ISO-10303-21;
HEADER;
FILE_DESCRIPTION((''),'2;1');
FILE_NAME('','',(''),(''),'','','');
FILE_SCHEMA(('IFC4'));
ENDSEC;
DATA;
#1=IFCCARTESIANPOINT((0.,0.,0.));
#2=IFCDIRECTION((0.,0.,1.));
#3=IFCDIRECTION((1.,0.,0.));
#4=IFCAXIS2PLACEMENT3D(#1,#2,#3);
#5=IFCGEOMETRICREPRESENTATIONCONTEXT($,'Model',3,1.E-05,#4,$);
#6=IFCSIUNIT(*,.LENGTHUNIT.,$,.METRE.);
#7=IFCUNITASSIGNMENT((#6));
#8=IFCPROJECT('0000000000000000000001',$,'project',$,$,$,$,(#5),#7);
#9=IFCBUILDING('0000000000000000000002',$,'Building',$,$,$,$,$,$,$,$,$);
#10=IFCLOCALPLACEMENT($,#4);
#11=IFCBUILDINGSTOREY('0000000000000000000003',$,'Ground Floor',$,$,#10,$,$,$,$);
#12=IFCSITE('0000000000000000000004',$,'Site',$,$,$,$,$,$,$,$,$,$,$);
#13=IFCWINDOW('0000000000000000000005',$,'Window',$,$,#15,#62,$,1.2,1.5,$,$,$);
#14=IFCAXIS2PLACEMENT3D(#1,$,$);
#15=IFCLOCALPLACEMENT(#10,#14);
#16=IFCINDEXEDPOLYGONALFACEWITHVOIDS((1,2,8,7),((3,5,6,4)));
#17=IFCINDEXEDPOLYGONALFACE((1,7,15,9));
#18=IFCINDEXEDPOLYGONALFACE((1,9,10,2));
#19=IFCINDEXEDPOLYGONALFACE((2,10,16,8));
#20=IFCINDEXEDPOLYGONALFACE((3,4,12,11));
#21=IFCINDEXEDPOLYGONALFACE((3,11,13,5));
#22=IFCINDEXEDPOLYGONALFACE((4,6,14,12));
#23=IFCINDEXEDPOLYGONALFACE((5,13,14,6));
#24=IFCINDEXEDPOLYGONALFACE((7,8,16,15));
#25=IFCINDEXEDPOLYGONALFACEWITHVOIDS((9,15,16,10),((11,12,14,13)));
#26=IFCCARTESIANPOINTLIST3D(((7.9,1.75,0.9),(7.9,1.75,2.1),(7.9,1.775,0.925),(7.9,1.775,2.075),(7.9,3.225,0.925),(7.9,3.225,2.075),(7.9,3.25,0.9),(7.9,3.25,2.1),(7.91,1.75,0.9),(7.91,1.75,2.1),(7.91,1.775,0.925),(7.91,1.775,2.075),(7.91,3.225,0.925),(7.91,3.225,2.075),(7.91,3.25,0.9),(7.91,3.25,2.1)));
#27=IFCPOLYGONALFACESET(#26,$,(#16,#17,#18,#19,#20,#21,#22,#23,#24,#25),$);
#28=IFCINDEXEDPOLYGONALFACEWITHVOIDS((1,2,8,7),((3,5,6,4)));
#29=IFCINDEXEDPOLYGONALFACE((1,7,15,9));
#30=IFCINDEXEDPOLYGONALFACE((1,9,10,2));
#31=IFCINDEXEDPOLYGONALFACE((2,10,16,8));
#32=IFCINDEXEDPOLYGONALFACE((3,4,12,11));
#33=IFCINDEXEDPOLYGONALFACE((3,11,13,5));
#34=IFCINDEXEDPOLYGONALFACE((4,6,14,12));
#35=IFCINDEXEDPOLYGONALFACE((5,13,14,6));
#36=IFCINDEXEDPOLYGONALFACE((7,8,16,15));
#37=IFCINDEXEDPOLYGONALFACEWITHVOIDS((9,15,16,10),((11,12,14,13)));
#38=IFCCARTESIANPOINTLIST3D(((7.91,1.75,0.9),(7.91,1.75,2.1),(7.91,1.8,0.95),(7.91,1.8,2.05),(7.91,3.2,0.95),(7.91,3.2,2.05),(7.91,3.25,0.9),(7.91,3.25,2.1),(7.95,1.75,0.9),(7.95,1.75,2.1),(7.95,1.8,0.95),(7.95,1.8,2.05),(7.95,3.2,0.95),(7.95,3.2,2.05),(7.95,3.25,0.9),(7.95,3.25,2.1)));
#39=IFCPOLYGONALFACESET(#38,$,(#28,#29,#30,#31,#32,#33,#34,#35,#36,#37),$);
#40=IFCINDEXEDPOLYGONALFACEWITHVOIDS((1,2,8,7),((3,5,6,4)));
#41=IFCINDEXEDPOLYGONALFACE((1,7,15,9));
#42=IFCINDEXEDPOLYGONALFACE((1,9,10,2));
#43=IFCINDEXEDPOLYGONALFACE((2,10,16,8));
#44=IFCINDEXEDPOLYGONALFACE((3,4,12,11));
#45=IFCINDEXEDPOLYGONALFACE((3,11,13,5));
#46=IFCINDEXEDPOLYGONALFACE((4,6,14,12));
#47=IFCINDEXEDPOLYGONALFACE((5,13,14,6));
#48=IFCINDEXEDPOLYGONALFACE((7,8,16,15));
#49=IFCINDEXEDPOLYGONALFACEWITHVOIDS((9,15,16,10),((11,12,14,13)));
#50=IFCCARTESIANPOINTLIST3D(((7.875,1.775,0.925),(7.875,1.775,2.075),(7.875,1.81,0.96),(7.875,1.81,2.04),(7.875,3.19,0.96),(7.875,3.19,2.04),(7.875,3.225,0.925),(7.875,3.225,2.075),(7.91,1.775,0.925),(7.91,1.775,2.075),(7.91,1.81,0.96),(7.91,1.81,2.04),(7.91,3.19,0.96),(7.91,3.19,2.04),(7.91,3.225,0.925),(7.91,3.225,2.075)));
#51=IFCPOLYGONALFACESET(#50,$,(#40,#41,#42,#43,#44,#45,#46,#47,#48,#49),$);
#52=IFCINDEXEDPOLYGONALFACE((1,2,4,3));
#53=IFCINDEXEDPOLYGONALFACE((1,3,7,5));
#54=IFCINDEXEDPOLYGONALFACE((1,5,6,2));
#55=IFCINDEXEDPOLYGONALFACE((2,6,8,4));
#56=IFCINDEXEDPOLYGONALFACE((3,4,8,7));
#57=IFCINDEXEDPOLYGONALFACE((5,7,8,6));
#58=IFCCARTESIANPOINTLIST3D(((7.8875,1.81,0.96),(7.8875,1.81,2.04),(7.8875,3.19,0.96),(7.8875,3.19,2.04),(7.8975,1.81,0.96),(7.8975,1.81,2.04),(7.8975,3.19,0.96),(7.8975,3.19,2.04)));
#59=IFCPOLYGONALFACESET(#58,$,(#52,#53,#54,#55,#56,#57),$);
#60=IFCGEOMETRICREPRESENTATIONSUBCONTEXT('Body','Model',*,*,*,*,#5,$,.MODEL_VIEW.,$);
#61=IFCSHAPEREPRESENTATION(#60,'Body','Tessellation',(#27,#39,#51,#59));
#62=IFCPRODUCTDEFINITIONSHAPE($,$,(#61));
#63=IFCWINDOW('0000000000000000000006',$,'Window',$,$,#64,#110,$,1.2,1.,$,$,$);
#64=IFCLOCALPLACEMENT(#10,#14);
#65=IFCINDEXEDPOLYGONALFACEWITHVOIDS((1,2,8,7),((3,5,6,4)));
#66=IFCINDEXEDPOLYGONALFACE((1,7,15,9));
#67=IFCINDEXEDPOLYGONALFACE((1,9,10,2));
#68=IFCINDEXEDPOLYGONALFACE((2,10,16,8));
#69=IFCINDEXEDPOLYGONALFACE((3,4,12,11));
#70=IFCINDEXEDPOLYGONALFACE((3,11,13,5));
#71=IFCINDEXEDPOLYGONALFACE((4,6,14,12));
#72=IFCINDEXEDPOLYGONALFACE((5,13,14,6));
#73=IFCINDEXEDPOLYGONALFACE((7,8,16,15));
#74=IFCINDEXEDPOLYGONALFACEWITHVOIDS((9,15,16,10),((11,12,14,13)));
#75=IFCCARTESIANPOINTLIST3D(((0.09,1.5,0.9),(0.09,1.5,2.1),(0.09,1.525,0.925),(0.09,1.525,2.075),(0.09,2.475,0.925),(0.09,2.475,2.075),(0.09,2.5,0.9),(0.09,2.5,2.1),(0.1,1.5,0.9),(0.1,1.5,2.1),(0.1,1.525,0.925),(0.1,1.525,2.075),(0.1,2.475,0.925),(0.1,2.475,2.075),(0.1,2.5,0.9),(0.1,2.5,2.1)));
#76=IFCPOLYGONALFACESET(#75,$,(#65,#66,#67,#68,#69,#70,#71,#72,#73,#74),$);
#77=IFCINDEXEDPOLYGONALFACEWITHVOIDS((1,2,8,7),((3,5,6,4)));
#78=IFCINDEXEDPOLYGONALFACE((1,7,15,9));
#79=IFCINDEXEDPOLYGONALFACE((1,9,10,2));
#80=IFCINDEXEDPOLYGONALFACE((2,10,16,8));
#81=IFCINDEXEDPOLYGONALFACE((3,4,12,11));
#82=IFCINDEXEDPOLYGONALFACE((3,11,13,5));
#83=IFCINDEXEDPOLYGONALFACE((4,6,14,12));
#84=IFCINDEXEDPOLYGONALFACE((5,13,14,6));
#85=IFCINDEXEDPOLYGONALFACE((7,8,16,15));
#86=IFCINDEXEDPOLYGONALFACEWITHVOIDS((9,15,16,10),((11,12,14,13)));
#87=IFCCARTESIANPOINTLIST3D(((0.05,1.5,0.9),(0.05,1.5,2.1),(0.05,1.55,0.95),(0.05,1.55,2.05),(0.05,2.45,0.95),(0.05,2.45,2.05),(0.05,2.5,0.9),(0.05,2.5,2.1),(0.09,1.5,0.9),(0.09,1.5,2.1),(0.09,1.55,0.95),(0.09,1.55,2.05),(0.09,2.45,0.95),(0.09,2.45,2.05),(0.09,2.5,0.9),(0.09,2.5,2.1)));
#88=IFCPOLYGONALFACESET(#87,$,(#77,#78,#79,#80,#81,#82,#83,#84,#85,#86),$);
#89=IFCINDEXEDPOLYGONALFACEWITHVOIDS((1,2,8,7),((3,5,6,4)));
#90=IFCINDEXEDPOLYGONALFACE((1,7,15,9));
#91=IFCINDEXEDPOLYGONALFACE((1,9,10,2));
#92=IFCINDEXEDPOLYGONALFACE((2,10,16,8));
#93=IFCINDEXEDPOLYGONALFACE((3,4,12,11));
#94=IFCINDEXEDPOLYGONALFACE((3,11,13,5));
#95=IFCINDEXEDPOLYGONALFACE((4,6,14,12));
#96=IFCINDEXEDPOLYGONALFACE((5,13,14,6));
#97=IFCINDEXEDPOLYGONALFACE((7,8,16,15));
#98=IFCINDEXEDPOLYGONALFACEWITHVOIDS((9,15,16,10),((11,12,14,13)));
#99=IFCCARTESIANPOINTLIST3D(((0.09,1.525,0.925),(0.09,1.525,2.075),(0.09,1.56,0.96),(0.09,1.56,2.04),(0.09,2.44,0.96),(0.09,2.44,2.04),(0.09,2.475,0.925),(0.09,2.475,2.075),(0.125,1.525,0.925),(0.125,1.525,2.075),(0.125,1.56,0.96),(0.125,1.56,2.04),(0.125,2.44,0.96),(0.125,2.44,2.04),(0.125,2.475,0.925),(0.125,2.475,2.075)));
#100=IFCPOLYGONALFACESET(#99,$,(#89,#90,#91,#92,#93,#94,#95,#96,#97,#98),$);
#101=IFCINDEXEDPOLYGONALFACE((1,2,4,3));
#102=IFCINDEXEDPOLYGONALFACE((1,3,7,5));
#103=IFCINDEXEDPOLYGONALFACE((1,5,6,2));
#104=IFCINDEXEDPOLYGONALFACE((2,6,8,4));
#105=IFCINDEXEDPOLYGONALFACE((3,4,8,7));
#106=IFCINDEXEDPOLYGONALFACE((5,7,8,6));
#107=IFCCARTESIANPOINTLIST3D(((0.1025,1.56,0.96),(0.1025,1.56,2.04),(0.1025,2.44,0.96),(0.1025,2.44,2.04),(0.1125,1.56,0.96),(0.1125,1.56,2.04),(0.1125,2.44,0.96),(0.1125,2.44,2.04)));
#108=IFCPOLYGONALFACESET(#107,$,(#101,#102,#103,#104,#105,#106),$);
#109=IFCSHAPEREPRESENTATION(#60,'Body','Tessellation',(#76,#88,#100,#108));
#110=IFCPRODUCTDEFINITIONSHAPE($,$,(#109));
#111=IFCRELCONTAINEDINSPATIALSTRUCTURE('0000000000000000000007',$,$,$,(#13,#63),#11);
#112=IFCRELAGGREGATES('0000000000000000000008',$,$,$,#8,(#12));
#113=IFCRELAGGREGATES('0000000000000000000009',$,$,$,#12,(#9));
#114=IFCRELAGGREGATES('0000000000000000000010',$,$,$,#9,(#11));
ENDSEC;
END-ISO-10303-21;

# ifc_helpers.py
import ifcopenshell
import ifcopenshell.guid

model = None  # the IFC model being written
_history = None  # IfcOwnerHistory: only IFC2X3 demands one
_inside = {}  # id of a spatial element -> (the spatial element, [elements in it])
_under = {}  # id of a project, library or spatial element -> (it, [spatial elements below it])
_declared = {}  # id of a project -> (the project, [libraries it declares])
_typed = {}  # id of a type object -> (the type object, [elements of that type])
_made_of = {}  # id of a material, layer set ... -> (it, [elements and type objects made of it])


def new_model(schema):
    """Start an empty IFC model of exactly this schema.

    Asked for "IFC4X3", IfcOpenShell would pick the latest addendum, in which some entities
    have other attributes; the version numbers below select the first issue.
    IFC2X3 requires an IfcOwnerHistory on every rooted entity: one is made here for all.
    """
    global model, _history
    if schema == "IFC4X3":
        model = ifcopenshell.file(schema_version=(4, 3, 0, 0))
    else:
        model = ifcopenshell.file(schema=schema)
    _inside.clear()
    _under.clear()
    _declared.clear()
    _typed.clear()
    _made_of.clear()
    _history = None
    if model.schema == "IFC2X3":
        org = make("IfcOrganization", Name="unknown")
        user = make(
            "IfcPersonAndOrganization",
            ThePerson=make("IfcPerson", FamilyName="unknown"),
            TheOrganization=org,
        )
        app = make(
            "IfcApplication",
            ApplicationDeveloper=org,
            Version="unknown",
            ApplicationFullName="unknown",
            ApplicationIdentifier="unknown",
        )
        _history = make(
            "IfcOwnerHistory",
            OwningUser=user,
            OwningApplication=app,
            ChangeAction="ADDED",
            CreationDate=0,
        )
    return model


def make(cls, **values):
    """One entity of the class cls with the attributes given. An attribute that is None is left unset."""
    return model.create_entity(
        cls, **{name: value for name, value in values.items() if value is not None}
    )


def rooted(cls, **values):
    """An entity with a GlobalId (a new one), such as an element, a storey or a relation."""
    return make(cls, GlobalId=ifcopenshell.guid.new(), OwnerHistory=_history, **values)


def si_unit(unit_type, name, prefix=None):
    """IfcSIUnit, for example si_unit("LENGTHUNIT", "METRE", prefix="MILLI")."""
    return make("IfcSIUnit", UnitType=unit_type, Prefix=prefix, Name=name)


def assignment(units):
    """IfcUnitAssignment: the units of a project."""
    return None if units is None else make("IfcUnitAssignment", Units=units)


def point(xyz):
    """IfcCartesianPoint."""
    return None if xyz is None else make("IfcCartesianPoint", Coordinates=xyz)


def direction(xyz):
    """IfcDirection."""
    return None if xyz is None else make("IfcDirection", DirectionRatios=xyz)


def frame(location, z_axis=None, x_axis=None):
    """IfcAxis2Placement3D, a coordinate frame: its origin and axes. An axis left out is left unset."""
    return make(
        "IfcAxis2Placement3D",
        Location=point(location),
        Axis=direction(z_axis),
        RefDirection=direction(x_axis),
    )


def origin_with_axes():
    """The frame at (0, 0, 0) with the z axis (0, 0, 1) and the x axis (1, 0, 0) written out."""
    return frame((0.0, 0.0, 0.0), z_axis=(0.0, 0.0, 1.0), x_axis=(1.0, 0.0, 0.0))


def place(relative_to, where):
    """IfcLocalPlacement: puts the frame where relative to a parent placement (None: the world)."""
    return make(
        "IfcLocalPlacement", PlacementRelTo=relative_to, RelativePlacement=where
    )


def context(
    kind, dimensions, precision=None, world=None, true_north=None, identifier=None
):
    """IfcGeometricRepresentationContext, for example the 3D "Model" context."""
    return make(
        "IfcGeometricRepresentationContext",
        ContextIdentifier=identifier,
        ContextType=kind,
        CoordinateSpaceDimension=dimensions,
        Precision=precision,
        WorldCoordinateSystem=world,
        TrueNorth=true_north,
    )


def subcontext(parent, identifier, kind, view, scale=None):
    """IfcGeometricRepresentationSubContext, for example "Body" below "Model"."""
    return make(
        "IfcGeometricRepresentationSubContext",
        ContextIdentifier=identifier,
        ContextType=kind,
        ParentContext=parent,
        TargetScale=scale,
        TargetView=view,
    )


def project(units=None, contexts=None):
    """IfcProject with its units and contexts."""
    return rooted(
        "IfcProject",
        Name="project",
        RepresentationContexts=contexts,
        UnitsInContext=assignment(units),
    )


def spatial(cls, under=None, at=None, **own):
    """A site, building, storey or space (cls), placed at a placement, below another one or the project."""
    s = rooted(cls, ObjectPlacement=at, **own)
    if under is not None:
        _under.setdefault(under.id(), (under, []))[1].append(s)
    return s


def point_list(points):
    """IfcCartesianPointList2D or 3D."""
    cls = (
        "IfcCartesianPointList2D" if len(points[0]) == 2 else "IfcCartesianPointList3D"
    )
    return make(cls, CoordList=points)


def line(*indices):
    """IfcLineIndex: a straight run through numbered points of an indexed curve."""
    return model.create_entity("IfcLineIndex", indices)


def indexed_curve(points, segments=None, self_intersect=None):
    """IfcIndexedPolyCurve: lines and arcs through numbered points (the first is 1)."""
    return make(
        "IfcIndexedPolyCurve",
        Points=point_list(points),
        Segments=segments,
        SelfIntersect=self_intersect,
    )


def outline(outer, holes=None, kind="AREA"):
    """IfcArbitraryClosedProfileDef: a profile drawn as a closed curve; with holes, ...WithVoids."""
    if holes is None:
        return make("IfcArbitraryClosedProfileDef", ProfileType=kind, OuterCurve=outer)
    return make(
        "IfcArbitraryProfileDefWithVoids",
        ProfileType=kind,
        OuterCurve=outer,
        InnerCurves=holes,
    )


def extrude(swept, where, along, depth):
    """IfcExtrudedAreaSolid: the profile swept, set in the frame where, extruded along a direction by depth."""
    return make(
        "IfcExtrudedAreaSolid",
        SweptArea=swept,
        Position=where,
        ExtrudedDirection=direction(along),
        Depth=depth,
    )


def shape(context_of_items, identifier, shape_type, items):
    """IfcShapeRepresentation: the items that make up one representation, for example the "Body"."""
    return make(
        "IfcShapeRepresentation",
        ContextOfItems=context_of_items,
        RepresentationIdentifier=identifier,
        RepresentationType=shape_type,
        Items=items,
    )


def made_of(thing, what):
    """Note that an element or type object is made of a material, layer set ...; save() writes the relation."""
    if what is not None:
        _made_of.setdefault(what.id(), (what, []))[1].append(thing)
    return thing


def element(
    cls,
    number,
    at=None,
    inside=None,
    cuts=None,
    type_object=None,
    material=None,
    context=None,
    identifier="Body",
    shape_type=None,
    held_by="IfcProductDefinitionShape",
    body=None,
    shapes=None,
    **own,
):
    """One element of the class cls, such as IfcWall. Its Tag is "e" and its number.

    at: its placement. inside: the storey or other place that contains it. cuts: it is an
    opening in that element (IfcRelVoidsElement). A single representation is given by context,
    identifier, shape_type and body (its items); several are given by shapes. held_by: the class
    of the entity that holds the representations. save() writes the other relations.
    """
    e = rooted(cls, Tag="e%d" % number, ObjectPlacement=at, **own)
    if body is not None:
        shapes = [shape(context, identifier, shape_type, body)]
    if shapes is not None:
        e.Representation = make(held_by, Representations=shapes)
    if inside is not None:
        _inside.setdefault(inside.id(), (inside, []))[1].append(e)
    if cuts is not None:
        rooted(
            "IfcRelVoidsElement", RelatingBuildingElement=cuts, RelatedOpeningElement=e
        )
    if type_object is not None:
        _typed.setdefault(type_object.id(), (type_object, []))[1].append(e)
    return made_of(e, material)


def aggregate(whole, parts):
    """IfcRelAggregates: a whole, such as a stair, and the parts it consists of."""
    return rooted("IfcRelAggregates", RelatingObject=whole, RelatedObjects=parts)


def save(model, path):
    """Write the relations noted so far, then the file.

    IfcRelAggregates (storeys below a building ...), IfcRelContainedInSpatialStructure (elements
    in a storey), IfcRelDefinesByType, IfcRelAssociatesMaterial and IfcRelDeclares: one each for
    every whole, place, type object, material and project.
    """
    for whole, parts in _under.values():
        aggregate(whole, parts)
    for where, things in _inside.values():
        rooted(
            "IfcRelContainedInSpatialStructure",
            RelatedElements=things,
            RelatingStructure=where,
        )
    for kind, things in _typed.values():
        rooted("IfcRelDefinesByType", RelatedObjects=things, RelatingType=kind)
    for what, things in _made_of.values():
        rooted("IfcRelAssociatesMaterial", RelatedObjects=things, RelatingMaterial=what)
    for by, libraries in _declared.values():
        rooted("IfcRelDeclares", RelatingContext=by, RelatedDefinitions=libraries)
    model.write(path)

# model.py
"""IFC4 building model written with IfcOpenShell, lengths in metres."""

from ifc_helpers import new_model, si_unit, frame, origin_with_axes, place, context, subcontext, project, spatial, line, indexed_curve, outline, extrude, element, save


model = new_model("IFC4")

# Units and contexts
model_context = context("Model", 3, precision=1e-05, world=origin_with_axes())
body_context = subcontext(model_context, "Body", "Model", "MODEL_VIEW")
ifc_project = project(units=[si_unit("LENGTHUNIT", "METRE")], contexts=[model_context])

# Site, building, storey
site = spatial("IfcSite", under=ifc_project, Name="Site")
building = spatial("IfcBuilding", under=site, Name="Building")
storey_placement = place(None, origin_with_axes())
storey = spatial("IfcBuildingStorey", under=building, at=storey_placement, Name="Ground Floor")

# Windows
for number, where, z_axis, x_axis, name in (
    (1, (8.0, 1.75, 0.9), (0.0, 0.0, 1.0), (0.0, 1.0, 0.0), "Window"),
):
    element("IfcWindow", number, at=place(storey_placement, frame(where, z_axis=z_axis, x_axis=x_axis)), inside=storey, Name=name, OverallHeight=1.2, OverallWidth=1.5, context=body_context, shape_type="SweptSolid", body=[
        extrude(outline(indexed_curve([(0.0, 0.0), (1.5, 0.0), (1.5, 1.2), (0.0, 1.2)], segments=[line(1, 2, 3, 4, 1)]), holes=[indexed_curve([(0.025, 0.025), (1.475, 0.025), (1.475, 1.175), (0.025, 1.175)], segments=[line(1, 2, 3, 4, 1)])]), frame((0.0, 0.09, 0.0), z_axis=(0.0, -1.0, 0.0), x_axis=(1.0, 0.0, 0.0)), (0.0, 0.0, -1.0), 0.01),
        extrude(outline(indexed_curve([(0.0, 0.0), (1.5, 0.0), (1.5, 1.2), (0.0, 1.2)], segments=[line(1, 2, 3, 4, 1)]), holes=[indexed_curve([(0.05, 0.05), (1.45, 0.05), (1.45, 1.15), (0.05, 1.15)], segments=[line(1, 2, 3, 4, 1)])]), frame((0.0, 0.05, 0.0), z_axis=(0.0, -1.0, 0.0), x_axis=(1.0, 0.0, 0.0)), (0.0, 0.0, -1.0), 0.04),
        extrude(outline(indexed_curve([(0.0, 0.0), (1.45, 0.0), (1.45, 1.15), (0.0, 1.15)], segments=[line(1, 2, 3, 4, 1)]), holes=[indexed_curve([(0.035, 0.035), (1.415, 0.035), (1.415, 1.115), (0.035, 1.115)], segments=[line(1, 2, 3, 4, 1)])]), frame((0.025, 0.09, 0.025), z_axis=(0.0, -1.0, 0.0), x_axis=(1.0, 0.0, 0.0)), (0.0, 0.0, -1.0), 0.035),
        extrude(outline(indexed_curve([(0.035, 0.035), (1.415, 0.035), (1.415, 1.115), (0.035, 1.115)], segments=[line(1, 2, 3, 4, 1)])), frame((0.025, 0.1025, 0.025), z_axis=(0.0, -1.0, 0.0), x_axis=(1.0, 0.0, 0.0)), (0.0, 0.0, -1.0), 0.01),
    ])
window_1_placement = place(storey_placement, frame((0.0, 2.5, 0.9), z_axis=(0.0, 0.0, 1.0), x_axis=(0.0, -1.0, 0.0)))
element("IfcWindow", 2, at=window_1_placement, inside=storey, Name="Window", OverallHeight=1.2, OverallWidth=1.0, context=body_context, shape_type="SweptSolid", body=[
    extrude(outline(indexed_curve([(0.0, 0.0), (1.0, 0.0), (1.0, 1.2), (0.0, 1.2)], segments=[line(1, 2, 3, 4, 1)]), holes=[indexed_curve([(0.025, 0.025), (0.975, 0.025), (0.975, 1.175), (0.025, 1.175)], segments=[line(1, 2, 3, 4, 1)])]), frame((0.0, 0.09, 0.0), z_axis=(0.0, -1.0, 0.0), x_axis=(1.0, 0.0, 0.0)), (0.0, 0.0, -1.0), 0.01),
    extrude(outline(indexed_curve([(0.0, 0.0), (1.0, 0.0), (1.0, 1.2), (0.0, 1.2)], segments=[line(1, 2, 3, 4, 1)]), holes=[indexed_curve([(0.05, 0.05), (0.95, 0.05), (0.95, 1.15), (0.05, 1.15)], segments=[line(1, 2, 3, 4, 1)])]), frame((0.0, 0.05, 0.0), z_axis=(0.0, -1.0, 0.0), x_axis=(1.0, 0.0, 0.0)), (0.0, 0.0, -1.0), 0.04),
    extrude(outline(indexed_curve([(0.0, 0.0), (0.95, 0.0), (0.95, 1.15), (0.0, 1.15)], segments=[line(1, 2, 3, 4, 1)]), holes=[indexed_curve([(0.035, 0.035), (0.915, 0.035), (0.915, 1.115), (0.035, 1.115)], segments=[line(1, 2, 3, 4, 1)])]), frame((0.025, 0.09, 0.025), z_axis=(0.0, -1.0, 0.0), x_axis=(1.0, 0.0, 0.0)), (0.0, 0.0, -1.0), 0.035),
    extrude(outline(indexed_curve([(0.035, 0.035), (0.915, 0.035), (0.915, 1.115), (0.035, 1.115)], segments=[line(1, 2, 3, 4, 1)])), frame((0.025, 0.1025, 0.025), z_axis=(0.0, -1.0, 0.0), x_axis=(1.0, 0.0, 0.0)), (0.0, 0.0, -1.0), 0.01),
])

save(model, "model.ifc")
